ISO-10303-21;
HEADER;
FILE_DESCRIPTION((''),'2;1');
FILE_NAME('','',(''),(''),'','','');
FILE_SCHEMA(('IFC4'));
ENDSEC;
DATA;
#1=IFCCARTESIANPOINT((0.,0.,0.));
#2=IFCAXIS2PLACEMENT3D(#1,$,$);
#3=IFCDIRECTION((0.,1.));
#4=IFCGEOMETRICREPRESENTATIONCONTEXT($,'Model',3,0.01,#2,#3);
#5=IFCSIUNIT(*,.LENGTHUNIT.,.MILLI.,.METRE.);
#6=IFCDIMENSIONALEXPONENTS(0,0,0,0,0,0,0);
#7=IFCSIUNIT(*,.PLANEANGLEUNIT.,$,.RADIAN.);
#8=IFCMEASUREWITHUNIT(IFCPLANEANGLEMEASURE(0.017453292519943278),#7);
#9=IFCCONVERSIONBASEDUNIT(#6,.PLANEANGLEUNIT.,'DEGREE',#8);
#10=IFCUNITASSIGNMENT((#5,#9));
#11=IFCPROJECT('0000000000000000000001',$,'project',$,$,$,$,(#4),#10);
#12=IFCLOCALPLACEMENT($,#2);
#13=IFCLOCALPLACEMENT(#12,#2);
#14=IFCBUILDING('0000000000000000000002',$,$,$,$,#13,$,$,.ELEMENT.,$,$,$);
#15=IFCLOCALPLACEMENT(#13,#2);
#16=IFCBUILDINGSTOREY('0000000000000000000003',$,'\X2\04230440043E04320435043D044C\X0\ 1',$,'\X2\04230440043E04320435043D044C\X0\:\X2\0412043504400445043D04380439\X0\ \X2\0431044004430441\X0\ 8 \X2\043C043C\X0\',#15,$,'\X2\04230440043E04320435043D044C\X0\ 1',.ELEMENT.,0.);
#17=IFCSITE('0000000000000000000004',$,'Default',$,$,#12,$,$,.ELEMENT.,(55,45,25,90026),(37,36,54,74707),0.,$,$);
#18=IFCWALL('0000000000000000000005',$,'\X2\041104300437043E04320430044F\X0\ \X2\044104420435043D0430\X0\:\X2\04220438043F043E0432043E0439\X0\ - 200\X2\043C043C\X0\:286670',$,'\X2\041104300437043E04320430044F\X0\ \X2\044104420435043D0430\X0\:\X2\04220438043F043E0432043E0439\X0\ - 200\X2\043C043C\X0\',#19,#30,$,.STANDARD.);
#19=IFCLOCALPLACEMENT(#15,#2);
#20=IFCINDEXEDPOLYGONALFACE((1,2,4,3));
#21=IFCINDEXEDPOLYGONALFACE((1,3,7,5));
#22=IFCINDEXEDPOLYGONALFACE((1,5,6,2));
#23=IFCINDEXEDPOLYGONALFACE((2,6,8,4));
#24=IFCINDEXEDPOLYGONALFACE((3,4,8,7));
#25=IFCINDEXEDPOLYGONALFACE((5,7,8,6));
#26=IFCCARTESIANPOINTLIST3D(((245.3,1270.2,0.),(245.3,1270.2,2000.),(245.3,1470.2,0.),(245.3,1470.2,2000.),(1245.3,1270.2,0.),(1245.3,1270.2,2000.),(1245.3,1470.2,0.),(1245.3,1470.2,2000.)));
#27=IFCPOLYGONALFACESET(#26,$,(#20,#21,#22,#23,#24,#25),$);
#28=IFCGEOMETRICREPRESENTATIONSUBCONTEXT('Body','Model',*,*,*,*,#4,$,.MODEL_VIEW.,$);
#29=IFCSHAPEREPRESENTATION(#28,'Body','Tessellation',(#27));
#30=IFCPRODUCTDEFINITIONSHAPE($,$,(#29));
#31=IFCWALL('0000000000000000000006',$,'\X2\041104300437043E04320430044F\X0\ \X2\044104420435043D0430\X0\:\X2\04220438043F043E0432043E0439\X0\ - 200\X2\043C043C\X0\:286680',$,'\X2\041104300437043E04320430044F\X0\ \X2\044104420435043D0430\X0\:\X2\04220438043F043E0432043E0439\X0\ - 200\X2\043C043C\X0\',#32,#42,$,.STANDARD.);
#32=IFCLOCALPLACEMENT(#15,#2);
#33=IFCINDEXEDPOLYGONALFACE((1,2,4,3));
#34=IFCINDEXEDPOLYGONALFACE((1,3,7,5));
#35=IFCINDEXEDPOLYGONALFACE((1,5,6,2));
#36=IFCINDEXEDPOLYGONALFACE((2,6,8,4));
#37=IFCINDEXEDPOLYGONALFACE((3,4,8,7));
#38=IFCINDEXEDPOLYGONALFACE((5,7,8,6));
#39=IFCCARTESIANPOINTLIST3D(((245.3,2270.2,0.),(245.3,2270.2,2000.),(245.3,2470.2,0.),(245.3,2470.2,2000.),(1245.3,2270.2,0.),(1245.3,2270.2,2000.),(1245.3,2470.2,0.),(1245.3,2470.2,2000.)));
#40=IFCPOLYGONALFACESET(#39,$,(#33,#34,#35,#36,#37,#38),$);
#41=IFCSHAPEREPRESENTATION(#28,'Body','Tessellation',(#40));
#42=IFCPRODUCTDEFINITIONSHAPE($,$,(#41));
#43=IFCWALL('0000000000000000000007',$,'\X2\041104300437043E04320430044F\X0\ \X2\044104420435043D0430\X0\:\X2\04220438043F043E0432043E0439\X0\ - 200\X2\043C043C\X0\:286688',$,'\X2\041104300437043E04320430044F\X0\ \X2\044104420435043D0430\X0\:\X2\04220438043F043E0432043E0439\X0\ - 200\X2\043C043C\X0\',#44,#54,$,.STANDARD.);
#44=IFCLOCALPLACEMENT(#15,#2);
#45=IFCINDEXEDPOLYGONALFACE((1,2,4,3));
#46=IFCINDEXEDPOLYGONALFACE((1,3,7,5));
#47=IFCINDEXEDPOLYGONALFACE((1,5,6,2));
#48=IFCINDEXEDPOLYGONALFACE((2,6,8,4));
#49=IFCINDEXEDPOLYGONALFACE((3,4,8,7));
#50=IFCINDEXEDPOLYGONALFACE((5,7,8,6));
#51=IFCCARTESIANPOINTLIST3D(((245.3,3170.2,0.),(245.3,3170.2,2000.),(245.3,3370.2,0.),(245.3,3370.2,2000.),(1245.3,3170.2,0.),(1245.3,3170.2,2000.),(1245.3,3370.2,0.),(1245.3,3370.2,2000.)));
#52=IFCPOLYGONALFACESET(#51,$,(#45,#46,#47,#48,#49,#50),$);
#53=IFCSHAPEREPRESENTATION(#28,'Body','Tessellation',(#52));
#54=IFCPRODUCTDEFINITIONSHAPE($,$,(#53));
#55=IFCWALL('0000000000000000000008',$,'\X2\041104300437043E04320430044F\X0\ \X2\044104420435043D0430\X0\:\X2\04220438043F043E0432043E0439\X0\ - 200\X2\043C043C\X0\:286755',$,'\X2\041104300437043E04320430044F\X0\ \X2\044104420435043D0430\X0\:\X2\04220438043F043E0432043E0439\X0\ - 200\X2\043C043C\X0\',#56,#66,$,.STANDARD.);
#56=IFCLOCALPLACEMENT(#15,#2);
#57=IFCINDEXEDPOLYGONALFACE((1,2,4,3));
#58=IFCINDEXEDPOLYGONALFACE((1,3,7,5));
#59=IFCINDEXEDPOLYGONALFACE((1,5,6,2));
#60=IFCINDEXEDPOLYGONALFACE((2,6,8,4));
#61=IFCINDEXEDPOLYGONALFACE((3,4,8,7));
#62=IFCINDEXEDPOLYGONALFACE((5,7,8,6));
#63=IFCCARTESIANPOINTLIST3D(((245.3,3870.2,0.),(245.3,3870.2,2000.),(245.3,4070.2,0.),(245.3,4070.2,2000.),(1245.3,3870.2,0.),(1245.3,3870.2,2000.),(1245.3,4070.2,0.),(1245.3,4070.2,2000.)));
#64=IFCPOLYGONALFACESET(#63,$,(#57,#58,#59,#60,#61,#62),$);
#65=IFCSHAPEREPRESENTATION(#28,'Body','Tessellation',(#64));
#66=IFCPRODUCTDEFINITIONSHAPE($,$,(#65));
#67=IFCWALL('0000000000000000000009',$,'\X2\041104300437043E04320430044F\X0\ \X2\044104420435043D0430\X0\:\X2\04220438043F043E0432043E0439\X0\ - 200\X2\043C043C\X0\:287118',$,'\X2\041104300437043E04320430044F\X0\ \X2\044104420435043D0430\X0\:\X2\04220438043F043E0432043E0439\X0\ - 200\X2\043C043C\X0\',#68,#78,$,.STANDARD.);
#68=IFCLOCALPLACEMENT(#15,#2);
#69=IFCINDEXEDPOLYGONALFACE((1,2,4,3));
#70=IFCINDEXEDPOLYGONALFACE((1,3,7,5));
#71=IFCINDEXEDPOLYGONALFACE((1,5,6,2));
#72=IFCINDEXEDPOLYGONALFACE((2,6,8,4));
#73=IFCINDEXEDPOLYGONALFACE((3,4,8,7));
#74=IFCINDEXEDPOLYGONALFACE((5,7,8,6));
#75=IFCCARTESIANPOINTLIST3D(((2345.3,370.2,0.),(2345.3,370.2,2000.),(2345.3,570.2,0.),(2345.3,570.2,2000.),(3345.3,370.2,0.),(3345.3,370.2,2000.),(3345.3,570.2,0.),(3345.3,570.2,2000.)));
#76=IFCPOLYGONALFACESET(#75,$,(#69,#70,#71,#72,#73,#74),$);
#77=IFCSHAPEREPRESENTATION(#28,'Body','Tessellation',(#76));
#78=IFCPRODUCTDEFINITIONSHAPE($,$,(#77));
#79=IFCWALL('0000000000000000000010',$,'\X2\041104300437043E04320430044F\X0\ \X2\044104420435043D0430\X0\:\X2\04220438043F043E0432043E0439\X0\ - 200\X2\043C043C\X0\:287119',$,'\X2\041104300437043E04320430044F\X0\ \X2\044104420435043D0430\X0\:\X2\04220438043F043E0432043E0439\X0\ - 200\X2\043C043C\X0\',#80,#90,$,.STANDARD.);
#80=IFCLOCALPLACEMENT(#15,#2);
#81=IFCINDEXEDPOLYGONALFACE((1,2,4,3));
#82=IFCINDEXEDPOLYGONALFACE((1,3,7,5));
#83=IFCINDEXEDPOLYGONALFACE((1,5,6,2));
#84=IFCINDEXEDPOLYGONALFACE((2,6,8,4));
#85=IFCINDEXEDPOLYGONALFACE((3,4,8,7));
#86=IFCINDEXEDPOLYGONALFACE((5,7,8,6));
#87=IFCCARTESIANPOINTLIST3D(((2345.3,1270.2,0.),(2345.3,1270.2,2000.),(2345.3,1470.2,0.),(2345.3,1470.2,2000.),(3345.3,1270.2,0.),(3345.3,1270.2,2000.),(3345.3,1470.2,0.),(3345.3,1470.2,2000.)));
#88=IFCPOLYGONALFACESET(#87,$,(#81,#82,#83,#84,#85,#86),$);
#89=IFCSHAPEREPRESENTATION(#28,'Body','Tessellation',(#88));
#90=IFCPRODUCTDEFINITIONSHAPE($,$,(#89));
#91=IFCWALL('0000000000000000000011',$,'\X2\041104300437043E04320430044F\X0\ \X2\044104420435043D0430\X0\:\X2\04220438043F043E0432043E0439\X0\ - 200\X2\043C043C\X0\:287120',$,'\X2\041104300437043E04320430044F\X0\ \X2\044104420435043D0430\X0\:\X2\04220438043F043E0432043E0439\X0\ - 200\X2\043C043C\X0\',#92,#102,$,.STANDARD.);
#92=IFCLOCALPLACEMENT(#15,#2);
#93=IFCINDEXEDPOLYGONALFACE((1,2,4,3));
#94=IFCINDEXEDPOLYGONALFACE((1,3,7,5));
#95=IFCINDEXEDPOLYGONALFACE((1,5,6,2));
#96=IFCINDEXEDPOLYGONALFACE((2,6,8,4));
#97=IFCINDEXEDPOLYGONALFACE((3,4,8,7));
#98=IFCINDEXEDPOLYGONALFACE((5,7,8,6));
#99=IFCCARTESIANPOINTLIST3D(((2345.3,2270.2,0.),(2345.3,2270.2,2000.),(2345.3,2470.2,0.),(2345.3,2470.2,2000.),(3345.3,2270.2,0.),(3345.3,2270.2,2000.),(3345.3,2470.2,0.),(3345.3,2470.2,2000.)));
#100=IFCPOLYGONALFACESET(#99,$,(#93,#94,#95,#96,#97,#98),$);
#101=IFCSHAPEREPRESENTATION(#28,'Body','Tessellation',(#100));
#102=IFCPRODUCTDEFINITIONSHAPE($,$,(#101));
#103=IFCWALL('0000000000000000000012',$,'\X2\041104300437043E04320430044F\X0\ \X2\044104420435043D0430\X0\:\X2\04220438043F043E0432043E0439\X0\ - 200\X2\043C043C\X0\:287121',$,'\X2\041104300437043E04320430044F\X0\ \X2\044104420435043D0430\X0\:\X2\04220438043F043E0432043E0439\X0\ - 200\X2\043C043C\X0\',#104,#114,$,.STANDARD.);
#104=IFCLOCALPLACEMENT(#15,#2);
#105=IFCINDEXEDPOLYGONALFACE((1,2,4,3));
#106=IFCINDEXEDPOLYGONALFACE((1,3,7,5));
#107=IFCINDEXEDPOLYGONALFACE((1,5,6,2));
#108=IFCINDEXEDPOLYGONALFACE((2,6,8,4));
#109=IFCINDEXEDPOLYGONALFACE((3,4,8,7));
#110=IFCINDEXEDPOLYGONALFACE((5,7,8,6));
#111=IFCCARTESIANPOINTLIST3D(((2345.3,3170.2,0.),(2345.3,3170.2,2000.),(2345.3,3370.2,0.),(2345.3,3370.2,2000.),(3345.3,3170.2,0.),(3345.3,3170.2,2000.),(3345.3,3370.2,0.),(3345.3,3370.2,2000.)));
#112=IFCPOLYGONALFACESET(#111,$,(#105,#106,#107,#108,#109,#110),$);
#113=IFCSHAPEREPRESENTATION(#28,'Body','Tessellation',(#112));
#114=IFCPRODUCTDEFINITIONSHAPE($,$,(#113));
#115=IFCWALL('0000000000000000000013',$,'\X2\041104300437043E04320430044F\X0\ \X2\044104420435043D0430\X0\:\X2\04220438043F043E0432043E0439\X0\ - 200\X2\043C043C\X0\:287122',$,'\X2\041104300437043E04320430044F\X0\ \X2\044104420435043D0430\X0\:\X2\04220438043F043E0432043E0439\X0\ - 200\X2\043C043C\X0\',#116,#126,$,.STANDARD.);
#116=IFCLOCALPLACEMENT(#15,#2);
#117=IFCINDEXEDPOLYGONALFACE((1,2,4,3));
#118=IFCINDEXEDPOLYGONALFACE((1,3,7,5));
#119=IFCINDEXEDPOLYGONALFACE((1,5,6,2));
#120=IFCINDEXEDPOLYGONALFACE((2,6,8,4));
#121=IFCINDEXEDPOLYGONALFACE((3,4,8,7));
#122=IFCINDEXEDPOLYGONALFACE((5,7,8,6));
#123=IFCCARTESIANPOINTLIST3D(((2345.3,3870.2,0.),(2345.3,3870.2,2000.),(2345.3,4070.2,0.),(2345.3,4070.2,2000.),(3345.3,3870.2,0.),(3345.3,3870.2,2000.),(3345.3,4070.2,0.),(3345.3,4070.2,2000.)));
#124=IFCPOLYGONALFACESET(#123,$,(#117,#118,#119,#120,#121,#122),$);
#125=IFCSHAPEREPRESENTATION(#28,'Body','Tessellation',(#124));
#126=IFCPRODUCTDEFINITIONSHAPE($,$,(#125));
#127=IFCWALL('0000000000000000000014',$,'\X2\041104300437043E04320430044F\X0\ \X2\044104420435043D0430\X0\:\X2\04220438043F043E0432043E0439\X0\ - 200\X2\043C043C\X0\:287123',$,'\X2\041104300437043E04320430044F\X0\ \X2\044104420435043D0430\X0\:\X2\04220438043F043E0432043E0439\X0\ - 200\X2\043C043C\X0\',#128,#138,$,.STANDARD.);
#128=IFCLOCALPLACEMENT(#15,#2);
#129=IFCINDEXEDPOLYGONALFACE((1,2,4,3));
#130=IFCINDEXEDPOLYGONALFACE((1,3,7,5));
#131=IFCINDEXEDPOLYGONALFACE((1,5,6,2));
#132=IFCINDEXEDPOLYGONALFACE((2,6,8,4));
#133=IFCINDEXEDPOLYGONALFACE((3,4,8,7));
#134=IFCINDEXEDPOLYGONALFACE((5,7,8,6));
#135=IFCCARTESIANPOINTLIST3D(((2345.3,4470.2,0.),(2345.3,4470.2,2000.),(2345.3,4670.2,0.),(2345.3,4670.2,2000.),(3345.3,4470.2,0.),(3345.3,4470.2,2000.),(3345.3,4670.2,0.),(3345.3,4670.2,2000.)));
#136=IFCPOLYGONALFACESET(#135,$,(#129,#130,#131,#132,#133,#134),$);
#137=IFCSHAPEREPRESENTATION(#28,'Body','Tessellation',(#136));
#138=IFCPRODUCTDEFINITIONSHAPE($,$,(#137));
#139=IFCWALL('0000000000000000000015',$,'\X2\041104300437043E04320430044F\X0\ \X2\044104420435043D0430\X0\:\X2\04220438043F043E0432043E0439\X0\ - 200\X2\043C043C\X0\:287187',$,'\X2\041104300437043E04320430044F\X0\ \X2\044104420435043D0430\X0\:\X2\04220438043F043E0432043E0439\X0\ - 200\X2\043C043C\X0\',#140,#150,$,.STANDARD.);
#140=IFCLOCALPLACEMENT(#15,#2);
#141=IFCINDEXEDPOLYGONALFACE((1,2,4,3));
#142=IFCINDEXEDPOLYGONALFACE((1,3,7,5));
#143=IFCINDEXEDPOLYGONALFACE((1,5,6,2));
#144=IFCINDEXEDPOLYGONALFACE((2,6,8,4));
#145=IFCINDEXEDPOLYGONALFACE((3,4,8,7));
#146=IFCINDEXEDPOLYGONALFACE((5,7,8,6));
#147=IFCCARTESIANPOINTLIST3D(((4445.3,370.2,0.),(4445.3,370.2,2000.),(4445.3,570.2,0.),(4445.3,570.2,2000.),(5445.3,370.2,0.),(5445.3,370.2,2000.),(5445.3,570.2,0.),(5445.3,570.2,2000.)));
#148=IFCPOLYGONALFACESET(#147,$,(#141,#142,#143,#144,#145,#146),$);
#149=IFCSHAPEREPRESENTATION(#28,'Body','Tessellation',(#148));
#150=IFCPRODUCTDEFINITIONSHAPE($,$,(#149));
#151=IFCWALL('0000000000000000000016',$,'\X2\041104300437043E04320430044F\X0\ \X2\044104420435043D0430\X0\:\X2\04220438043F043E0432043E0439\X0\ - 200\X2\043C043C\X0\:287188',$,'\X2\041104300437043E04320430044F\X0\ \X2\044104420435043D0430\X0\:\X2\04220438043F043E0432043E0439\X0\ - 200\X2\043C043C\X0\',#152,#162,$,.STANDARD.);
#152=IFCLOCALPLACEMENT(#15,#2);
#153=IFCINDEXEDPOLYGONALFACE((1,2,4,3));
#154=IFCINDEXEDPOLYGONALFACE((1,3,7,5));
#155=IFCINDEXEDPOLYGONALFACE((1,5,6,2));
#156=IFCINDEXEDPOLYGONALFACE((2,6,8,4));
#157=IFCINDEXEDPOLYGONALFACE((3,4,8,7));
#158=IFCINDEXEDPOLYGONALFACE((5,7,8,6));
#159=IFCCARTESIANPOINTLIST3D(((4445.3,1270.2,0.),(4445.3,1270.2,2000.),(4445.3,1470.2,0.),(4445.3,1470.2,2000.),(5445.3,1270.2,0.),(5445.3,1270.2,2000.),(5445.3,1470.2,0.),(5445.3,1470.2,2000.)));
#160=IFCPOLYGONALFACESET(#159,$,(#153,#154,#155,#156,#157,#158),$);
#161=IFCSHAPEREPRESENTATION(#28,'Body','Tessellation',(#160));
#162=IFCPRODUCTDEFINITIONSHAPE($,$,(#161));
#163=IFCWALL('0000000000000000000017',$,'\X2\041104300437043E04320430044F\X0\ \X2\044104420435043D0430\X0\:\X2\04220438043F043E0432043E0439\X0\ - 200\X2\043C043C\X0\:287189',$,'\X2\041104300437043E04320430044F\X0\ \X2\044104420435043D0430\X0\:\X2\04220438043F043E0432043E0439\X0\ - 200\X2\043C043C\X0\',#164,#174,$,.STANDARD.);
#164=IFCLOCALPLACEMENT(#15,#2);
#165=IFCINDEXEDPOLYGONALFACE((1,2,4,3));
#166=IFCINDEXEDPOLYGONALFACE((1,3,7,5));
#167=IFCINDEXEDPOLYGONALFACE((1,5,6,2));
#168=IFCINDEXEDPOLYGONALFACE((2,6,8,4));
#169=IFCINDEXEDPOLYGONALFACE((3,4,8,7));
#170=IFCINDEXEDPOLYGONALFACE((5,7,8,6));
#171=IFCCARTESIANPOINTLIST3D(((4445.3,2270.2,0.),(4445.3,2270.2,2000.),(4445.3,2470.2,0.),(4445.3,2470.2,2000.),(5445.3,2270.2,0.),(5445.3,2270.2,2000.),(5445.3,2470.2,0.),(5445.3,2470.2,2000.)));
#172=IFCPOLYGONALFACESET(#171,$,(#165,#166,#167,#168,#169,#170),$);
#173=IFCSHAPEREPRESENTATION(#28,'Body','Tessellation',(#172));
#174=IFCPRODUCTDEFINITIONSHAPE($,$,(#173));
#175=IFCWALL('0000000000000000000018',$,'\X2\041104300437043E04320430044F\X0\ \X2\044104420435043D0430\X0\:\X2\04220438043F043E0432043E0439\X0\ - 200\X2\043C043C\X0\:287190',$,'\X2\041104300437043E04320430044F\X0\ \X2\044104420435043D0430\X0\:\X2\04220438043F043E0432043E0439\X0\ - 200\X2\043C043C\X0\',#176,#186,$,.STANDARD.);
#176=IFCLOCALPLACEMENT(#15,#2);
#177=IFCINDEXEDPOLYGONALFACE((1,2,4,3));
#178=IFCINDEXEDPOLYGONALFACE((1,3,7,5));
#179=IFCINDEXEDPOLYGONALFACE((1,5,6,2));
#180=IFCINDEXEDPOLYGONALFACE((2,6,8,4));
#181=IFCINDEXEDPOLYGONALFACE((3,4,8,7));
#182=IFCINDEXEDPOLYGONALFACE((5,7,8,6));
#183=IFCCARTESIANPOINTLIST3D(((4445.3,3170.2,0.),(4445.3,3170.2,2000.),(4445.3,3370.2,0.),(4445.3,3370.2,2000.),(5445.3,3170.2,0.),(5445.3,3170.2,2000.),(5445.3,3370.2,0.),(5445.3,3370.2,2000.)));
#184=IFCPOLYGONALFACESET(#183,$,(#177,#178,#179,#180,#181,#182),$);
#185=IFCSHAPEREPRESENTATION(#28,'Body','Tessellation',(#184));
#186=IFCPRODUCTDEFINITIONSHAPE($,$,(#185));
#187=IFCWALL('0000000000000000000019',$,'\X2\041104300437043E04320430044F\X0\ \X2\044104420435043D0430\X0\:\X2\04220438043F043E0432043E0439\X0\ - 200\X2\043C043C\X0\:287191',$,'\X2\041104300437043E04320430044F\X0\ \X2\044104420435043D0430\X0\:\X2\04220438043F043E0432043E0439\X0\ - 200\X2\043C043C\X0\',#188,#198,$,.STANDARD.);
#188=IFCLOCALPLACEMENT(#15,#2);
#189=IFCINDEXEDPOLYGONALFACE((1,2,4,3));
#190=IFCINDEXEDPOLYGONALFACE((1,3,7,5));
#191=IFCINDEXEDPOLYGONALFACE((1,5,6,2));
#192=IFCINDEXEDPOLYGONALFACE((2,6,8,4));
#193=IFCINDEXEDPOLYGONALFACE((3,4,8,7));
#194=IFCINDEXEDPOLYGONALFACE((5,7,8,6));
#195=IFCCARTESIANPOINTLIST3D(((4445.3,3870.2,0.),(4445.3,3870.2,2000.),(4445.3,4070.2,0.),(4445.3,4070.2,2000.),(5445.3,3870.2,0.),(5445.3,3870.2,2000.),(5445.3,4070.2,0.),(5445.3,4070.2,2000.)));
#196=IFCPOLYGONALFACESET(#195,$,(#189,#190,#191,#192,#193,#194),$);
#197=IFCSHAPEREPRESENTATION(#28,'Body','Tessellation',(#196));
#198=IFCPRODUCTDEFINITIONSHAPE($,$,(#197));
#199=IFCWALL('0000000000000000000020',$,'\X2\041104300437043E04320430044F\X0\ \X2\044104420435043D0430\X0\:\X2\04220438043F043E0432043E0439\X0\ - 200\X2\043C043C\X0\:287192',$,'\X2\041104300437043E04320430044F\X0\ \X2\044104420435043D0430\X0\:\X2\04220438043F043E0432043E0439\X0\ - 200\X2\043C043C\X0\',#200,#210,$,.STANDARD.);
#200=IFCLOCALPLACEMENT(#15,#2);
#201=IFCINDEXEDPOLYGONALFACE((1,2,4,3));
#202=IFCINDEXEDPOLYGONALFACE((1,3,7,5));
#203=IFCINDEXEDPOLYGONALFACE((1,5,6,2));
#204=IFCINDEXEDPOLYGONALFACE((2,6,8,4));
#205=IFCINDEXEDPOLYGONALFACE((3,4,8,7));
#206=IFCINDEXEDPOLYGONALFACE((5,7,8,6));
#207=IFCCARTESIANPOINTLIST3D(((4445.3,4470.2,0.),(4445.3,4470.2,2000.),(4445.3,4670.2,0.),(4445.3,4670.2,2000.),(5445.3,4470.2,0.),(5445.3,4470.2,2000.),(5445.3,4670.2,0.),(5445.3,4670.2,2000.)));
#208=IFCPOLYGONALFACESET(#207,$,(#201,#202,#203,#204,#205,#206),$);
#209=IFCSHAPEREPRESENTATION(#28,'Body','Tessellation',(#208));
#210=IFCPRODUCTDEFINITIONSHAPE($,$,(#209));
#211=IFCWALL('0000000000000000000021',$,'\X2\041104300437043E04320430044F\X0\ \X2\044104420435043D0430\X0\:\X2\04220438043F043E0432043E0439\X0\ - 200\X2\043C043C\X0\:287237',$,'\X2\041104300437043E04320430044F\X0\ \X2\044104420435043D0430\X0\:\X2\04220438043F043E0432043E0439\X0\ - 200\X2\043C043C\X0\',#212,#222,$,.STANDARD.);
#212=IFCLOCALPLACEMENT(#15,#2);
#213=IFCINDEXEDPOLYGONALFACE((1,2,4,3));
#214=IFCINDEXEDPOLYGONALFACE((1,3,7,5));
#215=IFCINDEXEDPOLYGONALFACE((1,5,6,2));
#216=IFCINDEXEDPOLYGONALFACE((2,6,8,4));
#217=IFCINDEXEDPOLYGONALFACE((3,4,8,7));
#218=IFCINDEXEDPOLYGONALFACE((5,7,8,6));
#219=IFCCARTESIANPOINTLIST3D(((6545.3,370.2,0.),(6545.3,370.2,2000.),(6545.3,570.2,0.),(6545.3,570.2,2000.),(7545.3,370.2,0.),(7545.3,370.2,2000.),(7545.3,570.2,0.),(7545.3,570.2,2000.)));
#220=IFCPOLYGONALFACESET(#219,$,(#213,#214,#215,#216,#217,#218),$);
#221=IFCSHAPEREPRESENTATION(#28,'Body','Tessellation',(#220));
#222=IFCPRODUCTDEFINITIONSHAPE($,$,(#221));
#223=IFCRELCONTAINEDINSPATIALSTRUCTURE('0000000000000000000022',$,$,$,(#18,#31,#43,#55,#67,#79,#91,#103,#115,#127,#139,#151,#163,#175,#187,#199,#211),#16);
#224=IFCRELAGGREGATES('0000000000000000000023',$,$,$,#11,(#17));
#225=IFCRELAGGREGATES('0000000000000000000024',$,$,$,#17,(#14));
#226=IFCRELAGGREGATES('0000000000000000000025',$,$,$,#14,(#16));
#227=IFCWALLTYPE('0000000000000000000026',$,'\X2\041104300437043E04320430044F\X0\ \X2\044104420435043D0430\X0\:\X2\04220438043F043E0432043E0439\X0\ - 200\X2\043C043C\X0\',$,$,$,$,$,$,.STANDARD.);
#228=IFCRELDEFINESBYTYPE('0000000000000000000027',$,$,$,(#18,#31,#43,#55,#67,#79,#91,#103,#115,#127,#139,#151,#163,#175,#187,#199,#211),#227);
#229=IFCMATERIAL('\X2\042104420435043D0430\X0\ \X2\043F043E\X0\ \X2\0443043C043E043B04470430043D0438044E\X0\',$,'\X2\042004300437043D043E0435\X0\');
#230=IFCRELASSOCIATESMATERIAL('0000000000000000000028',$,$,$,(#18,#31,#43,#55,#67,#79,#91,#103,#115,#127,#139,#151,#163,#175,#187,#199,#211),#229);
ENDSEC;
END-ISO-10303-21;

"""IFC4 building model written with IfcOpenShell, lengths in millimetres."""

from ifc_helpers import new_model, entity, si_unit, converted_unit, direction, frame, origin, place, context, subcontext, project, spatial, indexed_curve, outline, extrude, material, type_object, element, save


model = new_model("IFC4")

# Units and contexts
model_context = context("Model", 3, precision=0.01, world=origin(), true_north=direction((0.0, 1.0)))
body_context = subcontext(model_context, "Body", "Model", "MODEL_VIEW")
ifc_project = project(units=[si_unit("LENGTHUNIT", "METRE", prefix="MILLI"), converted_unit("PLANEANGLEUNIT", "DEGREE", entity("IfcPlaneAngleMeasure", 0.017453292519943278), si_unit("PLANEANGLEUNIT", "RADIAN"), dimensions=[0, 0, 0, 0, 0, 0, 0])], contexts=[model_context])

# Site, building, storey
site_placement = place(None, origin())
site = spatial("IfcSite", under=ifc_project, at=site_placement, Name="Default", CompositionType="ELEMENT", RefLatitude=(55, 45, 25, 90026), RefLongitude=(37, 36, 54, 74707), RefElevation=0.0)
building_placement = place(site_placement, origin())
building = spatial("IfcBuilding", under=site, at=building_placement, CompositionType="ELEMENT")
storey_placement = place(building_placement, origin())
storey = spatial("IfcBuildingStorey", under=building, at=storey_placement, Name="Уровень 1", ObjectType="Уровень:Верхний брус 8 мм", LongName="Уровень 1", CompositionType="ELEMENT", Elevation=0.0)

# Walls
ifc_material = material(Name="Стена по умолчанию", Category="Разное")
wall_type = type_object("IfcWallType", Name="Базовая стена:Типовой - 200мм", PredefinedType="STANDARD")
wall_1_placement = place(storey_placement, frame((245.3, 1370.2, 0.0)))
element("IfcWall", 1, at=wall_1_placement, inside=storey, type_object=wall_type, material=ifc_material, Name="Базовая стена:Типовой - 200мм:286670", ObjectType="Базовая стена:Типовой - 200мм", PredefinedType="STANDARD", context=body_context, shape_type="SweptSolid", body=[
    extrude(outline(indexed_curve([(1000.0, 100.0), (0.0, 100.0), (0.0, -100.0), (1000.0, -100.0), (1000.0, 100.0)], self_intersect=False)), origin(), (0.0, 0.0, 1.0), 2000.0),
])
for number, where, name in (
    (2, (245.3, 2370.2, 0.0), "Базовая стена:Типовой - 200мм:286680"),
    (3, (245.3, 3270.2, 0.0), "Базовая стена:Типовой - 200мм:286688"),
    (4, (245.3, 3970.2, 0.0), "Базовая стена:Типовой - 200мм:286755"),
    (5, (2345.3, 470.2, 0.0), "Базовая стена:Типовой - 200мм:287118"),
    (6, (2345.3, 1370.2, 0.0), "Базовая стена:Типовой - 200мм:287119"),
):
    element("IfcWall", number, at=place(storey_placement, frame(where)), inside=storey, type_object=wall_type, material=ifc_material, Name=name, ObjectType="Базовая стена:Типовой - 200мм", PredefinedType="STANDARD", context=body_context, shape_type="SweptSolid", body=[
        extrude(outline(indexed_curve([(1000.0, 100.0), (0.0, 100.0), (0.0, -100.0), (1000.0, -100.0), (1000.0, 100.0)], self_intersect=False)), origin(), (0.0, 0.0, 1.0), 2000.0),
    ])
for number, where, name in (
    (7, (2345.3, 2370.2, 0.0), "Базовая стена:Типовой - 200мм:287120"),
    (8, (2345.3, 3270.2, 0.0), "Базовая стена:Типовой - 200мм:287121"),
    (9, (2345.3, 3970.2, 0.0), "Базовая стена:Типовой - 200мм:287122"),
):
    element("IfcWall", number, at=place(storey_placement, frame(where)), inside=storey, type_object=wall_type, material=ifc_material, Name=name, ObjectType="Базовая стена:Типовой - 200мм", PredefinedType="STANDARD", context=body_context, shape_type="SweptSolid", body=[
        extrude(outline(indexed_curve([(1000.0, 100.0), (0.0, 100.0), (0.0, -100.0), (1000.0, -100.0), (1000.0, 100.0)], self_intersect=False)), origin(), (0.0, 0.0, 1.0), 2000.0),
    ])
wall_2_placement = place(storey_placement, frame((2345.3, 4570.2, 0.0)))
element("IfcWall", 10, at=wall_2_placement, inside=storey, type_object=wall_type, material=ifc_material, Name="Базовая стена:Типовой - 200мм:287123", ObjectType="Базовая стена:Типовой - 200мм", PredefinedType="STANDARD", context=body_context, shape_type="SweptSolid", body=[
    extrude(outline(indexed_curve([(1000.0, 100.0), (0.0, 100.0), (0.0, -100.0), (1000.0, -100.0), (1000.0, 100.0)], self_intersect=False)), origin(), (0.0, 0.0, 1.0), 2000.0),
])
for number, where, name in (
    (11, (4445.3, 470.2, 0.0), "Базовая стена:Типовой - 200мм:287187"),
    (12, (4445.3, 1370.2, 0.0), "Базовая стена:Типовой - 200мм:287188"),
):
    element("IfcWall", number, at=place(storey_placement, frame(where)), inside=storey, type_object=wall_type, material=ifc_material, Name=name, ObjectType="Базовая стена:Типовой - 200мм", PredefinedType="STANDARD", context=body_context, shape_type="SweptSolid", body=[
        extrude(outline(indexed_curve([(1000.0, 100.0), (0.0, 100.0), (0.0, -100.0), (1000.0, -100.0), (1000.0, 100.0)], self_intersect=False)), origin(), (0.0, 0.0, 1.0), 2000.0),
    ])
for number, where, name in (
    (13, (4445.3, 2370.2, 0.0), "Базовая стена:Типовой - 200мм:287189"),
    (14, (4445.3, 3270.2, 0.0), "Базовая стена:Типовой - 200мм:287190"),
    (15, (4445.3, 3970.2, 0.0), "Базовая стена:Типовой - 200мм:287191"),
):
    element("IfcWall", number, at=place(storey_placement, frame(where)), inside=storey, type_object=wall_type, material=ifc_material, Name=name, ObjectType="Базовая стена:Типовой - 200мм", PredefinedType="STANDARD", context=body_context, shape_type="SweptSolid", body=[
        extrude(outline(indexed_curve([(1000.0, 100.0), (0.0, 100.0), (0.0, -100.0), (1000.0, -100.0), (1000.0, 100.0)], self_intersect=False)), origin(), (0.0, 0.0, 1.0), 2000.0),
    ])
wall_3_placement = place(storey_placement, frame((4445.3, 4570.2, 0.0)))
element("IfcWall", 16, at=wall_3_placement, inside=storey, type_object=wall_type, material=ifc_material, Name="Базовая стена:Типовой - 200мм:287192", ObjectType="Базовая стена:Типовой - 200мм", PredefinedType="STANDARD", context=body_context, shape_type="SweptSolid", body=[
    extrude(outline(indexed_curve([(1000.0, 100.0), (0.0, 100.0), (0.0, -100.0), (1000.0, -100.0), (1000.0, 100.0)], self_intersect=False)), origin(), (0.0, 0.0, 1.0), 2000.0),
])
for number, where, name in (
    (17, (6545.3, 470.2, 0.0), "Базовая стена:Типовой - 200мм:287237"),
):
    element("IfcWall", number, at=place(storey_placement, frame(where)), inside=storey, type_object=wall_type, material=ifc_material, Name=name, ObjectType="Базовая стена:Типовой - 200мм", PredefinedType="STANDARD", context=body_context, shape_type="SweptSolid", body=[
        extrude(outline(indexed_curve([(1000.0, 100.0), (0.0, 100.0), (0.0, -100.0), (1000.0, -100.0), (1000.0, 100.0)], self_intersect=False)), origin(), (0.0, 0.0, 1.0), 2000.0),
    ])

save(model, "model.ifc")
